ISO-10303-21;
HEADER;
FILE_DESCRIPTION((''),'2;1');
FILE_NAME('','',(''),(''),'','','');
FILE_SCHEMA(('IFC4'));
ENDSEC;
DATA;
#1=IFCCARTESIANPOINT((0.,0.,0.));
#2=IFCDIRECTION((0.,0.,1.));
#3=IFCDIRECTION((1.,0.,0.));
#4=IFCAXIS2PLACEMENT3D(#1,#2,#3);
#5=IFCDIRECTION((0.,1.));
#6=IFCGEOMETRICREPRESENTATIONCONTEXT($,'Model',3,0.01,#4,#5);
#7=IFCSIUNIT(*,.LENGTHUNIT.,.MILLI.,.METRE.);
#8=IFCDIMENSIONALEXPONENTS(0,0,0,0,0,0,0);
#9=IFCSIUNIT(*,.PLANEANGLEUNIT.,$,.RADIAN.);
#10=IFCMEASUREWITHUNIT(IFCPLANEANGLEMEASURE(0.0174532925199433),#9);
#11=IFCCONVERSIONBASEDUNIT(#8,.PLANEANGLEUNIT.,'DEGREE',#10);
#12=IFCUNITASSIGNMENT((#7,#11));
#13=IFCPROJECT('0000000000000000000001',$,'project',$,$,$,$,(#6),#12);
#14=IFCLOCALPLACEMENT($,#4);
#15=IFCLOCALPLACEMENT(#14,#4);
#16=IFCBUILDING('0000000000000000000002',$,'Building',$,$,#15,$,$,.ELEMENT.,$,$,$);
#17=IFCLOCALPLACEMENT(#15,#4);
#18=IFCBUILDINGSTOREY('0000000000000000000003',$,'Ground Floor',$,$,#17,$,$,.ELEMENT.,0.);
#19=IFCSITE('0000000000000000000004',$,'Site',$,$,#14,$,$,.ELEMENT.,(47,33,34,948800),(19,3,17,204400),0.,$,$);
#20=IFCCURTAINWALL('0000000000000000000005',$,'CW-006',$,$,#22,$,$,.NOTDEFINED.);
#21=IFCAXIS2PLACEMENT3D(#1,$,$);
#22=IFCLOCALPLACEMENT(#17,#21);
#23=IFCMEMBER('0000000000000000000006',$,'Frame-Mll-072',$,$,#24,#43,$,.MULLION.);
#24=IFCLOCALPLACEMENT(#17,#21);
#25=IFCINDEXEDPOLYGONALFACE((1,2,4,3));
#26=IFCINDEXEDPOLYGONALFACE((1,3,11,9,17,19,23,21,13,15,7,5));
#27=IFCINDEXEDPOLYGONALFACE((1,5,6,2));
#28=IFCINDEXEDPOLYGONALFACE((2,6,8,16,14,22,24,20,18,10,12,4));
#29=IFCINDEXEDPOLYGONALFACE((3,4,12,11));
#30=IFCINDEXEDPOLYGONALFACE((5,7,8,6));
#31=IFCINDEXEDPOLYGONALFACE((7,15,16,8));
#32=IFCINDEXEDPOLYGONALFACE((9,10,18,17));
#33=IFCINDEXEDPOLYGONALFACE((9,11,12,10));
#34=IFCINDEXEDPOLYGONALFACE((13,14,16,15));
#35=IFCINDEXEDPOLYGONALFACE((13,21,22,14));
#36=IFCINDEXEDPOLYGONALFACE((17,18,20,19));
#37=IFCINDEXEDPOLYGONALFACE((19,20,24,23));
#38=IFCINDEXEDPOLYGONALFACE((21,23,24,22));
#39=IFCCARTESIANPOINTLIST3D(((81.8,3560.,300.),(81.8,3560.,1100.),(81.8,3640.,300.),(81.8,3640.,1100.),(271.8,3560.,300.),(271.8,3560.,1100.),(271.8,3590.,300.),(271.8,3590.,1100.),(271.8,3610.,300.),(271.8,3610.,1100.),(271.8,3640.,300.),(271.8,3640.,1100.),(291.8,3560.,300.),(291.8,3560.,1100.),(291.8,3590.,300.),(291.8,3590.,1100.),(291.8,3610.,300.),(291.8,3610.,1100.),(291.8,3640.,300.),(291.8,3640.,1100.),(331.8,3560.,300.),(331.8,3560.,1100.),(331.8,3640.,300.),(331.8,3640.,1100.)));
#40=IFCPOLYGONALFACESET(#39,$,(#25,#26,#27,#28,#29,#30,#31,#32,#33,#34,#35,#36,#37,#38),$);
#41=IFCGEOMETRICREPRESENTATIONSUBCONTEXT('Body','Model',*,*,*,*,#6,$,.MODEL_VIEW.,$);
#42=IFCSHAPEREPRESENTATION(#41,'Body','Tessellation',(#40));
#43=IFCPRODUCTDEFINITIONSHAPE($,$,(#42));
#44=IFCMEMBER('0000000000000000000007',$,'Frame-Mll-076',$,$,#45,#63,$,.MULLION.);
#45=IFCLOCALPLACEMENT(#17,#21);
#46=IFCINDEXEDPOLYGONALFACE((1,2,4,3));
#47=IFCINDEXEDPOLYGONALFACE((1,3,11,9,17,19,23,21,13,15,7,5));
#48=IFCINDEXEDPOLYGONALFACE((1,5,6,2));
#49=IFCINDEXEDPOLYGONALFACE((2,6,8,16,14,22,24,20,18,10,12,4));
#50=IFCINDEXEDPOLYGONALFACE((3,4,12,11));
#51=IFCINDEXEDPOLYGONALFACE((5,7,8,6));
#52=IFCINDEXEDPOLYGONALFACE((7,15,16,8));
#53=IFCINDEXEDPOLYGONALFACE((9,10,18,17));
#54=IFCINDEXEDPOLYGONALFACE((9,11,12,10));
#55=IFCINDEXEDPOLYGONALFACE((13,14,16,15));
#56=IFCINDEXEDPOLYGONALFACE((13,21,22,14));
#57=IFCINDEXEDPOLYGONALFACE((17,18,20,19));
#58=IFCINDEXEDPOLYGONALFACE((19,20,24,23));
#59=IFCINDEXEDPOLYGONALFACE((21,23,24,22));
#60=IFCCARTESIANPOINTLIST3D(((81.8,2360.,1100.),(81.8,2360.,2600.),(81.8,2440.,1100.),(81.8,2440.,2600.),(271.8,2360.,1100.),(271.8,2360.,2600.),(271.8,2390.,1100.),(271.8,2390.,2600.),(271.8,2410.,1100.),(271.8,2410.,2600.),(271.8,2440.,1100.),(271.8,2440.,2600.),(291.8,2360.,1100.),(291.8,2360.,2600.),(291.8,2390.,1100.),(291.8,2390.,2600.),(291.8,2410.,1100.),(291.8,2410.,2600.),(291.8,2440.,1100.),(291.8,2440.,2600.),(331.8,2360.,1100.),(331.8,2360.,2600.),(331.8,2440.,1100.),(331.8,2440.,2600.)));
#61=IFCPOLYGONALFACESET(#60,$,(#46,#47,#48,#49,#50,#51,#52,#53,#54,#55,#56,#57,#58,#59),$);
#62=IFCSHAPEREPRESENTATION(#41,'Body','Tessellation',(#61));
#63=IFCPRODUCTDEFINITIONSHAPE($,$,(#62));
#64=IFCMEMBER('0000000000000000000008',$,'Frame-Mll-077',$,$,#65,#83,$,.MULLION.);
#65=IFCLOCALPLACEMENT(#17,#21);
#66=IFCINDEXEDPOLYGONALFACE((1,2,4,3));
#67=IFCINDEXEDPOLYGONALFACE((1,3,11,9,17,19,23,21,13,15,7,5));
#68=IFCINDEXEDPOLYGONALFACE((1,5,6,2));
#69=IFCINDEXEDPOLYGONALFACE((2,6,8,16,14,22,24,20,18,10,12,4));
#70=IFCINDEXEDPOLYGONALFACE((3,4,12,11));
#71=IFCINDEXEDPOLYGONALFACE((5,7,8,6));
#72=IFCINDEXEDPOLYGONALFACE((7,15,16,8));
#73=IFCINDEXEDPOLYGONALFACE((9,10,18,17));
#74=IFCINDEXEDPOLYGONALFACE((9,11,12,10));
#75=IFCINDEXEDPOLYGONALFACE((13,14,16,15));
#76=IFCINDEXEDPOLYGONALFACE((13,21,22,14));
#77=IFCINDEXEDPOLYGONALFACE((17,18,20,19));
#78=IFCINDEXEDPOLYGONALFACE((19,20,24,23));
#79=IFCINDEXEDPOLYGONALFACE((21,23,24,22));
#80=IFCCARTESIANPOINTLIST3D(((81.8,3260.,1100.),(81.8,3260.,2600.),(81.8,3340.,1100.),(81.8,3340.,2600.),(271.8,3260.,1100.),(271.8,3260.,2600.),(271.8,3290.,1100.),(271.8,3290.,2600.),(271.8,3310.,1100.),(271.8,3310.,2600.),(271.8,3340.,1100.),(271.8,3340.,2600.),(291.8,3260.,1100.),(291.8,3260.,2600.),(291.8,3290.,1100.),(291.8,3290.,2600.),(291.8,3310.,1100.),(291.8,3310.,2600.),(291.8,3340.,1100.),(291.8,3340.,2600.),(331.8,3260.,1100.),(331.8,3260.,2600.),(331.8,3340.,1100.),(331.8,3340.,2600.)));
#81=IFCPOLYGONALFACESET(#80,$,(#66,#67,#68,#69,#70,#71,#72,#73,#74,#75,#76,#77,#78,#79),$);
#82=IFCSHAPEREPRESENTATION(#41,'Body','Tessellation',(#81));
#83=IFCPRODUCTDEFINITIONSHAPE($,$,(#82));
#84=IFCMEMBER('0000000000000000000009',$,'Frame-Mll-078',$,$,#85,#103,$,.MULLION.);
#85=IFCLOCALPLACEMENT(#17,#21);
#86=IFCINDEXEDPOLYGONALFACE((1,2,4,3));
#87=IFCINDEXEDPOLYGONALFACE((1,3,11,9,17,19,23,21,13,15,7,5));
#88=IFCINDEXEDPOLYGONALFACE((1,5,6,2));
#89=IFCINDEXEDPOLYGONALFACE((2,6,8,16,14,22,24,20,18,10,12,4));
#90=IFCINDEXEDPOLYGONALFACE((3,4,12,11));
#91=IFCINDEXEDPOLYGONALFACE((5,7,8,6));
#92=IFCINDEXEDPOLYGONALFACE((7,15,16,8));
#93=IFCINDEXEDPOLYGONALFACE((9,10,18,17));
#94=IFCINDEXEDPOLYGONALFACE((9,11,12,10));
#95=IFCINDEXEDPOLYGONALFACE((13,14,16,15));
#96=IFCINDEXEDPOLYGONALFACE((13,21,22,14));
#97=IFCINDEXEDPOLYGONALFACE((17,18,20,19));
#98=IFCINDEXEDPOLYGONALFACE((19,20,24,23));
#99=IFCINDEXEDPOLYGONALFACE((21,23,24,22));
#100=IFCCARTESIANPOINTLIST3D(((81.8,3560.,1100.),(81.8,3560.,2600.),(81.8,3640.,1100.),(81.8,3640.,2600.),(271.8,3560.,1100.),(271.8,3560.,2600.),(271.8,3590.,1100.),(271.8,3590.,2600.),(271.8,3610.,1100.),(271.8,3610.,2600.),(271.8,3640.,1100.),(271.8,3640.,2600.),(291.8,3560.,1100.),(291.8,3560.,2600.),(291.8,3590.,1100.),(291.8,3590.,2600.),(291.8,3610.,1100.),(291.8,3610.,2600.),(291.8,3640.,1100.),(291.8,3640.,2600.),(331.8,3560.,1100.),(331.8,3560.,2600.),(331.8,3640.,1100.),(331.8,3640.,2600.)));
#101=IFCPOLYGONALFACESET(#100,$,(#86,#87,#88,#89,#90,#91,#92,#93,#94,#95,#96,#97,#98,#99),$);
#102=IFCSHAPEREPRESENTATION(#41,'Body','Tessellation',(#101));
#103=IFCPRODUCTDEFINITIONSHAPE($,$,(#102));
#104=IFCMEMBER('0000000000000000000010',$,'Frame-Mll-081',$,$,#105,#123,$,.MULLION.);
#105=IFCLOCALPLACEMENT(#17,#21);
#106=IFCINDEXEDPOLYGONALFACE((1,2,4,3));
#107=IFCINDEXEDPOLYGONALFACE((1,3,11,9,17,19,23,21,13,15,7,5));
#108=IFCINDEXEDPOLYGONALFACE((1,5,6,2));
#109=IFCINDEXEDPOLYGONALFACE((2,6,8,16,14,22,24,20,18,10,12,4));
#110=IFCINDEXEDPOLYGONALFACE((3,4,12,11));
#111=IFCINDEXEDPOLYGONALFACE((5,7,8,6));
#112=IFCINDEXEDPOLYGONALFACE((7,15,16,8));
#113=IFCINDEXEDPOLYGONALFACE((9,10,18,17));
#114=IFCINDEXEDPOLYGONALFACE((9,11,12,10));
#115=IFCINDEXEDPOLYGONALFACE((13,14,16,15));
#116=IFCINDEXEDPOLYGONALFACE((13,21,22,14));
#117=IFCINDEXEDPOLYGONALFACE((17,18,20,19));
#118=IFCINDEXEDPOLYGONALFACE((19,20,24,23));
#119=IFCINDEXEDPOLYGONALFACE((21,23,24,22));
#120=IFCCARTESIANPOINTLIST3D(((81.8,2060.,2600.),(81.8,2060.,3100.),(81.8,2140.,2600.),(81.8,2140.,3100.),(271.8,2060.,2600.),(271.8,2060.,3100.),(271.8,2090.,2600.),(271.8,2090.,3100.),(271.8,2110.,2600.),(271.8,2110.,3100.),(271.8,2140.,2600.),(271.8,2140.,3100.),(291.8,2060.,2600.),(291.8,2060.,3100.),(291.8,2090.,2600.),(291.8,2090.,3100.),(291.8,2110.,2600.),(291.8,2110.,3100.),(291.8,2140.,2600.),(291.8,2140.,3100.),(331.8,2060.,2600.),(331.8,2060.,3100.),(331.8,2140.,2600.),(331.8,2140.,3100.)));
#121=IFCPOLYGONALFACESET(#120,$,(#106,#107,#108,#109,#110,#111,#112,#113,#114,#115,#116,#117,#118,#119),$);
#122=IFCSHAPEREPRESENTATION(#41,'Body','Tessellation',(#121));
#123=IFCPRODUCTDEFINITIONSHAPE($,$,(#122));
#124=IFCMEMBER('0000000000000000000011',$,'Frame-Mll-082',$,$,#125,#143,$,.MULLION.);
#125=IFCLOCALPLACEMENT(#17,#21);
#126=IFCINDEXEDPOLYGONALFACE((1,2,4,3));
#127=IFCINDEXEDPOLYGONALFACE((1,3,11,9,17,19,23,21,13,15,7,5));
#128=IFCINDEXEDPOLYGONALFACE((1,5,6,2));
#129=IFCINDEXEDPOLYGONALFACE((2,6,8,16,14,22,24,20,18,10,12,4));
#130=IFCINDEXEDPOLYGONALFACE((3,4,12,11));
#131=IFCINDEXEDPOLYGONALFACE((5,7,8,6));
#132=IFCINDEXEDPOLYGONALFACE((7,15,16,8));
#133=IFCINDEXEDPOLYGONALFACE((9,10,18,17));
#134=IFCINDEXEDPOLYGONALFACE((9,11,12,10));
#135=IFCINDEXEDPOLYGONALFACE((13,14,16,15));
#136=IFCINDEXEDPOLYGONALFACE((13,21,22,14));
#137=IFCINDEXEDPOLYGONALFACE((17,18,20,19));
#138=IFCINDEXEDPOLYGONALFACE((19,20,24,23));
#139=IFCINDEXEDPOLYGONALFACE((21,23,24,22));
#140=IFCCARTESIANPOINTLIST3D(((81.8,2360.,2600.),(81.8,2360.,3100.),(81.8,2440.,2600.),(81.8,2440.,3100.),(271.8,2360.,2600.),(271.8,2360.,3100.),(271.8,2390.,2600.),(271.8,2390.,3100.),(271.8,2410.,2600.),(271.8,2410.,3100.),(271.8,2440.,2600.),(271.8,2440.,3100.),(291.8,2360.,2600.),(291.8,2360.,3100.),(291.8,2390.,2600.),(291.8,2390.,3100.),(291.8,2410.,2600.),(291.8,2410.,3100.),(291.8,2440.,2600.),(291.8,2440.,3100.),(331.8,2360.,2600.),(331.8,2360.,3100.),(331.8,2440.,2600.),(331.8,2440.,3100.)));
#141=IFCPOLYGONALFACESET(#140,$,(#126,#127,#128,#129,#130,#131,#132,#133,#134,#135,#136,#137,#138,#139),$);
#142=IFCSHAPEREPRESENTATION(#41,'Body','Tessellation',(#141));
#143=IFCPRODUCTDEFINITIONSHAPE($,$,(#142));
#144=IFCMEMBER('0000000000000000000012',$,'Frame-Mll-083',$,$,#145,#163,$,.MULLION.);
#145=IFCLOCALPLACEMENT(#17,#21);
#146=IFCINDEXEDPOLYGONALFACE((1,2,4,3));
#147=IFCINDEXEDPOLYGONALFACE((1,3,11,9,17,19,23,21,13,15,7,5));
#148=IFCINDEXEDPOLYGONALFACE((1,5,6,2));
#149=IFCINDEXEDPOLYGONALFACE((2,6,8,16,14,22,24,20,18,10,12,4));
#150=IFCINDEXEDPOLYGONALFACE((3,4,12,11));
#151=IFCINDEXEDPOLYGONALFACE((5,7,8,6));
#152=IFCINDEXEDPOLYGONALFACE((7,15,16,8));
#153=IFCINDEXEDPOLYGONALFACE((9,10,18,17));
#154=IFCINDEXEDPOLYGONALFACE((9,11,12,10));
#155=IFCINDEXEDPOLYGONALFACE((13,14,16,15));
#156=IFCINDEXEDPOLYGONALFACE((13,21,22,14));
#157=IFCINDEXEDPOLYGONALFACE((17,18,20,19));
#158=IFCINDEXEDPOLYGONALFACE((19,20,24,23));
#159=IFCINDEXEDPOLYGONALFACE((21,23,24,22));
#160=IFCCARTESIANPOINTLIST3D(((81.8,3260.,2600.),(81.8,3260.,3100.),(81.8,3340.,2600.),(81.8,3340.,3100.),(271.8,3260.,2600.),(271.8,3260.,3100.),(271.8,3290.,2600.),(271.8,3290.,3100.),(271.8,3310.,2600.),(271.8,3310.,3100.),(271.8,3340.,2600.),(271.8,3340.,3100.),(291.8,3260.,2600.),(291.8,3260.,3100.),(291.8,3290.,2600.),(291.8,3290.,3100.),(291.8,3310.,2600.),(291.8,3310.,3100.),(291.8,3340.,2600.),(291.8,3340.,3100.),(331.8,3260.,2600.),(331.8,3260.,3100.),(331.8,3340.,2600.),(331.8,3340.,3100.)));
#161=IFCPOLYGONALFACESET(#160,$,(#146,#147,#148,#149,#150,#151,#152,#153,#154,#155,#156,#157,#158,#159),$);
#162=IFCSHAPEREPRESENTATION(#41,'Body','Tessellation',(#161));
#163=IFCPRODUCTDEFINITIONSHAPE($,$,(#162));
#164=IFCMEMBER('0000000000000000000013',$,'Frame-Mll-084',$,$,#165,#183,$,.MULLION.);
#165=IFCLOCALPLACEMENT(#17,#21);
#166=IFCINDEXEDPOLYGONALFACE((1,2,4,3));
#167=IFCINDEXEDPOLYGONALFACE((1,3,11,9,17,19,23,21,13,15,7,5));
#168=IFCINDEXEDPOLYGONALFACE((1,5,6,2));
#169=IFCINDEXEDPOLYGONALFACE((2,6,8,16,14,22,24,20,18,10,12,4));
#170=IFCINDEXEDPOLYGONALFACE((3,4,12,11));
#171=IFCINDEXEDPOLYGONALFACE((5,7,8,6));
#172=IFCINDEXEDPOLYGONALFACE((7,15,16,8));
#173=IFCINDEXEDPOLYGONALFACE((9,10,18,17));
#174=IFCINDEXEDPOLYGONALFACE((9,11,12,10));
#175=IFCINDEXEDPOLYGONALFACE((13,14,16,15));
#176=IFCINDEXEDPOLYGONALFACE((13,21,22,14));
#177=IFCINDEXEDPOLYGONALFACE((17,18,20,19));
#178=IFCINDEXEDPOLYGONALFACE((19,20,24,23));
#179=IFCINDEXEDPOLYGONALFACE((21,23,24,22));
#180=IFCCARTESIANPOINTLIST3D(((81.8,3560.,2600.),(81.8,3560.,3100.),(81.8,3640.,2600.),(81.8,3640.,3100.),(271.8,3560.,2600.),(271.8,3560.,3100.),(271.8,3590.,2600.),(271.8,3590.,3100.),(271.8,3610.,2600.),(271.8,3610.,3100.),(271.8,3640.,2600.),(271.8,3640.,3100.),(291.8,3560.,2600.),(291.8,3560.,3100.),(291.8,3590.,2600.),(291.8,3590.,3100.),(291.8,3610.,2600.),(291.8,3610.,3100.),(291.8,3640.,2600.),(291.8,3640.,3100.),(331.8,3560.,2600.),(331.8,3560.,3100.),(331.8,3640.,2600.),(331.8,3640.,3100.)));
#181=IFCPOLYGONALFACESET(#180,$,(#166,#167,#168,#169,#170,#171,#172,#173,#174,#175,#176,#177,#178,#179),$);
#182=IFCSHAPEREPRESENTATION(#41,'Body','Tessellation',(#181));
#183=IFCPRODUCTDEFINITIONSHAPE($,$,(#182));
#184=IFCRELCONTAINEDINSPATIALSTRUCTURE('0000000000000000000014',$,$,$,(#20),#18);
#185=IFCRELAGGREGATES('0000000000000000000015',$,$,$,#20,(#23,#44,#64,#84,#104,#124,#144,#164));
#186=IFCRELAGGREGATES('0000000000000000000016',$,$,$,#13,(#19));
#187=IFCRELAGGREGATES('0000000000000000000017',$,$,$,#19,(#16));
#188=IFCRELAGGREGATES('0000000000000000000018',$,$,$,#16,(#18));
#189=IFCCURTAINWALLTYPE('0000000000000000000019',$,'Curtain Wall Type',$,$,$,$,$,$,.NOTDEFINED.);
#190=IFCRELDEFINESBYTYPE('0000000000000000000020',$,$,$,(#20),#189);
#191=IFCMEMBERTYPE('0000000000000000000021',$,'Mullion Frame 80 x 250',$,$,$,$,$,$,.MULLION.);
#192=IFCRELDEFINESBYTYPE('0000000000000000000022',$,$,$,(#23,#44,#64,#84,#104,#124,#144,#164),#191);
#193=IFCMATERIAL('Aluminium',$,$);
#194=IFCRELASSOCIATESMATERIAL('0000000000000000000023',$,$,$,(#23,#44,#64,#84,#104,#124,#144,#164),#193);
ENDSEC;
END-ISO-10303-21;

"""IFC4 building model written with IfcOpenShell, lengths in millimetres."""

from ifc_helpers import new_model, entity, si_unit, converted_unit, direction, frame, origin_with_axes, place, context, subcontext, project, spatial, line, indexed_curve, outline, extrude, material, type_object, element, aggregate, save


model = new_model("IFC4")

# Units and contexts
model_context = context("Model", 3, precision=0.01, world=origin_with_axes(), true_north=direction((0.0, 1.0)))
body_context = subcontext(model_context, "Body", "Model", "MODEL_VIEW")
ifc_project = project(units=[si_unit("LENGTHUNIT", "METRE", prefix="MILLI"), converted_unit("PLANEANGLEUNIT", "DEGREE", entity("IfcPlaneAngleMeasure", 0.0174532925199433), si_unit("PLANEANGLEUNIT", "RADIAN"), dimensions=[0, 0, 0, 0, 0, 0, 0])], contexts=[model_context])

# Site, building, storey
site_placement = place(None, origin_with_axes())
site = spatial("IfcSite", under=ifc_project, at=site_placement, Name="Site", CompositionType="ELEMENT", RefLatitude=(47, 33, 34, 948800), RefLongitude=(19, 3, 17, 204400), RefElevation=0.0)
building_placement = place(site_placement, origin_with_axes())
building = spatial("IfcBuilding", under=site, at=building_placement, Name="Building", CompositionType="ELEMENT")
storey_placement = place(building_placement, origin_with_axes())
storey = spatial("IfcBuildingStorey", under=building, at=storey_placement, Name="Ground Floor", CompositionType="ELEMENT", Elevation=0.0)

# Curtain wall, members
curtain_wall_type = type_object("IfcCurtainWallType", Name="Curtain Wall Type", PredefinedType="NOTDEFINED")
curtain_wall_placement = place(storey_placement, frame((281.8, 450.0, 200.0), z_axis=(0.0, 0.0, 1.0), x_axis=(1.0, 0.0, 0.0)))
curtain_wall = element("IfcCurtainWall", 1, at=curtain_wall_placement, inside=storey, type_object=curtain_wall_type, Name="CW-006", PredefinedType="NOTDEFINED")
ifc_material_1 = material(Name="Aluminium")
member_type_1 = type_object("IfcMemberType", Name="Mullion Frame 80 x 250", PredefinedType="MULLION")
member_1_placement = place(curtain_wall_placement, frame((0.0, 3150.0, 0.0), z_axis=(0.0, 0.0, 1.0), x_axis=(0.0, -1.0, 0.0)))
member_1 = element("IfcMember", 2, at=member_1_placement, type_object=member_type_1, material=ifc_material_1, Name="Frame-Mll-072", PredefinedType="MULLION", context=body_context, shape_type="SweptSolid", body=[
    extrude(outline(indexed_curve([(-10.0, -10.0), (-40.0, -10.0), (-40.0, -200.0), (40.0, -200.0), (40.0, -10.0), (10.0, -10.0), (10.0, 10.0), (40.0, 10.0), (40.0, 50.0), (-40.0, 50.0), (-40.0, 10.0), (-10.0, 10.0)], segments=[line(1, 2, 3, 4, 5, 6, 7, 8, 9, 10, 11, 12, 1)])), frame((0.0, 0.0, 100.0), z_axis=(0.0, 0.0, 1.0), x_axis=(1.0, 0.0, 0.0)), (0.0, 0.0, 1.0), 800.0),
])
member_2_placement = place(curtain_wall_placement, frame((0.0, 1950.0, 900.0), z_axis=(0.0, 0.0, 1.0), x_axis=(0.0, -1.0, 0.0)))
member_2 = element("IfcMember", 3, at=member_2_placement, type_object=member_type_1, material=ifc_material_1, Name="Frame-Mll-076", PredefinedType="MULLION", context=body_context, shape_type="SweptSolid", body=[
    extrude(outline(indexed_curve([(-10.0, -10.0), (-40.0, -10.0), (-40.0, -200.0), (40.0, -200.0), (40.0, -10.0), (10.0, -10.0), (10.0, 10.0), (40.0, 10.0), (40.0, 50.0), (-40.0, 50.0), (-40.0, 10.0), (-10.0, 10.0)], segments=[line(1, 2, 3, 4, 5, 6, 7, 8, 9, 10, 11, 12, 1)])), origin_with_axes(), (0.0, 0.0, 1.0), 1500.0),
])
member_3_placement = place(curtain_wall_placement, frame((0.0, 2850.0, 900.0), z_axis=(0.0, 0.0, 1.0), x_axis=(0.0, -1.0, 0.0)))
member_3 = element("IfcMember", 4, at=member_3_placement, type_object=member_type_1, material=ifc_material_1, Name="Frame-Mll-077", PredefinedType="MULLION", context=body_context, shape_type="SweptSolid", body=[
    extrude(outline(indexed_curve([(-10.0, -10.0), (-40.0, -10.0), (-40.0, -200.0), (40.0, -200.0), (40.0, -10.0), (10.0, -10.0), (10.0, 10.0), (40.0, 10.0), (40.0, 50.0), (-40.0, 50.0), (-40.0, 10.0), (-10.0, 10.0)], segments=[line(1, 2, 3, 4, 5, 6, 7, 8, 9, 10, 11, 12, 1)])), origin_with_axes(), (0.0, 0.0, 1.0), 1500.0),
])
member_4_placement = place(curtain_wall_placement, frame((0.0, 3150.0, 900.0), z_axis=(0.0, 0.0, 1.0), x_axis=(0.0, -1.0, 0.0)))
member_4 = element("IfcMember", 5, at=member_4_placement, type_object=member_type_1, material=ifc_material_1, Name="Frame-Mll-078", PredefinedType="MULLION", context=body_context, shape_type="SweptSolid", body=[
    extrude(outline(indexed_curve([(-10.0, -10.0), (-40.0, -10.0), (-40.0, -200.0), (40.0, -200.0), (40.0, -10.0), (10.0, -10.0), (10.0, 10.0), (40.0, 10.0), (40.0, 50.0), (-40.0, 50.0), (-40.0, 10.0), (-10.0, 10.0)], segments=[line(1, 2, 3, 4, 5, 6, 7, 8, 9, 10, 11, 12, 1)])), origin_with_axes(), (0.0, 0.0, 1.0), 1500.0),
])
member_5_placement = place(curtain_wall_placement, frame((0.0, 1650.0, 2400.0), z_axis=(0.0, 0.0, 1.0), x_axis=(0.0, -1.0, 0.0)))
member_5 = element("IfcMember", 6, at=member_5_placement, type_object=member_type_1, material=ifc_material_1, Name="Frame-Mll-081", PredefinedType="MULLION", context=body_context, shape_type="SweptSolid", body=[
    extrude(outline(indexed_curve([(-10.0, -10.0), (-40.0, -10.0), (-40.0, -200.0), (40.0, -200.0), (40.0, -10.0), (10.0, -10.0), (10.0, 10.0), (40.0, 10.0), (40.0, 50.0), (-40.0, 50.0), (-40.0, 10.0), (-10.0, 10.0)], segments=[line(1, 2, 3, 4, 5, 6, 7, 8, 9, 10, 11, 12, 1)])), origin_with_axes(), (0.0, 0.0, 1.0), 500.0),
])
member_6_placement = place(curtain_wall_placement, frame((0.0, 1950.0, 2400.0), z_axis=(0.0, 0.0, 1.0), x_axis=(0.0, -1.0, 0.0)))
member_6 = element("IfcMember", 7, at=member_6_placement, type_object=member_type_1, material=ifc_material_1, Name="Frame-Mll-082", PredefinedType="MULLION", context=body_context, shape_type="SweptSolid", body=[
    extrude(outline(indexed_curve([(-10.0, -10.0), (-40.0, -10.0), (-40.0, -200.0), (40.0, -200.0), (40.0, -10.0), (10.0, -10.0), (10.0, 10.0), (40.0, 10.0), (40.0, 50.0), (-40.0, 50.0), (-40.0, 10.0), (-10.0, 10.0)], segments=[line(1, 2, 3, 4, 5, 6, 7, 8, 9, 10, 11, 12, 1)])), origin_with_axes(), (0.0, 0.0, 1.0), 500.0),
])
member_7_placement = place(curtain_wall_placement, frame((0.0, 2850.0, 2400.0), z_axis=(0.0, 0.0, 1.0), x_axis=(0.0, -1.0, 0.0)))
member_7 = element("IfcMember", 8, at=member_7_placement, type_object=member_type_1, material=ifc_material_1, Name="Frame-Mll-083", PredefinedType="MULLION", context=body_context, shape_type="SweptSolid", body=[
    extrude(outline(indexed_curve([(-10.0, -10.0), (-40.0, -10.0), (-40.0, -200.0), (40.0, -200.0), (40.0, -10.0), (10.0, -10.0), (10.0, 10.0), (40.0, 10.0), (40.0, 50.0), (-40.0, 50.0), (-40.0, 10.0), (-10.0, 10.0)], segments=[line(1, 2, 3, 4, 5, 6, 7, 8, 9, 10, 11, 12, 1)])), origin_with_axes(), (0.0, 0.0, 1.0), 500.0),
])
member_8_placement = place(curtain_wall_placement, frame((0.0, 3150.0, 2400.0), z_axis=(0.0, 0.0, 1.0), x_axis=(0.0, -1.0, 0.0)))
member_8 = element("IfcMember", 9, at=member_8_placement, type_object=member_type_1, material=ifc_material_1, Name="Frame-Mll-084", PredefinedType="MULLION", context=body_context, shape_type="SweptSolid", body=[
    extrude(outline(indexed_curve([(-10.0, -10.0), (-40.0, -10.0), (-40.0, -200.0), (40.0, -200.0), (40.0, -10.0), (10.0, -10.0), (10.0, 10.0), (40.0, 10.0), (40.0, 50.0), (-40.0, 50.0), (-40.0, 10.0), (-10.0, 10.0)], segments=[line(1, 2, 3, 4, 5, 6, 7, 8, 9, 10, 11, 12, 1)])), origin_with_axes(), (0.0, 0.0, 1.0), 500.0),
])
aggregate(curtain_wall, [member_1, member_2, member_3, member_4, member_5, member_6, member_7, member_8])

save(model, "model.ifc")
